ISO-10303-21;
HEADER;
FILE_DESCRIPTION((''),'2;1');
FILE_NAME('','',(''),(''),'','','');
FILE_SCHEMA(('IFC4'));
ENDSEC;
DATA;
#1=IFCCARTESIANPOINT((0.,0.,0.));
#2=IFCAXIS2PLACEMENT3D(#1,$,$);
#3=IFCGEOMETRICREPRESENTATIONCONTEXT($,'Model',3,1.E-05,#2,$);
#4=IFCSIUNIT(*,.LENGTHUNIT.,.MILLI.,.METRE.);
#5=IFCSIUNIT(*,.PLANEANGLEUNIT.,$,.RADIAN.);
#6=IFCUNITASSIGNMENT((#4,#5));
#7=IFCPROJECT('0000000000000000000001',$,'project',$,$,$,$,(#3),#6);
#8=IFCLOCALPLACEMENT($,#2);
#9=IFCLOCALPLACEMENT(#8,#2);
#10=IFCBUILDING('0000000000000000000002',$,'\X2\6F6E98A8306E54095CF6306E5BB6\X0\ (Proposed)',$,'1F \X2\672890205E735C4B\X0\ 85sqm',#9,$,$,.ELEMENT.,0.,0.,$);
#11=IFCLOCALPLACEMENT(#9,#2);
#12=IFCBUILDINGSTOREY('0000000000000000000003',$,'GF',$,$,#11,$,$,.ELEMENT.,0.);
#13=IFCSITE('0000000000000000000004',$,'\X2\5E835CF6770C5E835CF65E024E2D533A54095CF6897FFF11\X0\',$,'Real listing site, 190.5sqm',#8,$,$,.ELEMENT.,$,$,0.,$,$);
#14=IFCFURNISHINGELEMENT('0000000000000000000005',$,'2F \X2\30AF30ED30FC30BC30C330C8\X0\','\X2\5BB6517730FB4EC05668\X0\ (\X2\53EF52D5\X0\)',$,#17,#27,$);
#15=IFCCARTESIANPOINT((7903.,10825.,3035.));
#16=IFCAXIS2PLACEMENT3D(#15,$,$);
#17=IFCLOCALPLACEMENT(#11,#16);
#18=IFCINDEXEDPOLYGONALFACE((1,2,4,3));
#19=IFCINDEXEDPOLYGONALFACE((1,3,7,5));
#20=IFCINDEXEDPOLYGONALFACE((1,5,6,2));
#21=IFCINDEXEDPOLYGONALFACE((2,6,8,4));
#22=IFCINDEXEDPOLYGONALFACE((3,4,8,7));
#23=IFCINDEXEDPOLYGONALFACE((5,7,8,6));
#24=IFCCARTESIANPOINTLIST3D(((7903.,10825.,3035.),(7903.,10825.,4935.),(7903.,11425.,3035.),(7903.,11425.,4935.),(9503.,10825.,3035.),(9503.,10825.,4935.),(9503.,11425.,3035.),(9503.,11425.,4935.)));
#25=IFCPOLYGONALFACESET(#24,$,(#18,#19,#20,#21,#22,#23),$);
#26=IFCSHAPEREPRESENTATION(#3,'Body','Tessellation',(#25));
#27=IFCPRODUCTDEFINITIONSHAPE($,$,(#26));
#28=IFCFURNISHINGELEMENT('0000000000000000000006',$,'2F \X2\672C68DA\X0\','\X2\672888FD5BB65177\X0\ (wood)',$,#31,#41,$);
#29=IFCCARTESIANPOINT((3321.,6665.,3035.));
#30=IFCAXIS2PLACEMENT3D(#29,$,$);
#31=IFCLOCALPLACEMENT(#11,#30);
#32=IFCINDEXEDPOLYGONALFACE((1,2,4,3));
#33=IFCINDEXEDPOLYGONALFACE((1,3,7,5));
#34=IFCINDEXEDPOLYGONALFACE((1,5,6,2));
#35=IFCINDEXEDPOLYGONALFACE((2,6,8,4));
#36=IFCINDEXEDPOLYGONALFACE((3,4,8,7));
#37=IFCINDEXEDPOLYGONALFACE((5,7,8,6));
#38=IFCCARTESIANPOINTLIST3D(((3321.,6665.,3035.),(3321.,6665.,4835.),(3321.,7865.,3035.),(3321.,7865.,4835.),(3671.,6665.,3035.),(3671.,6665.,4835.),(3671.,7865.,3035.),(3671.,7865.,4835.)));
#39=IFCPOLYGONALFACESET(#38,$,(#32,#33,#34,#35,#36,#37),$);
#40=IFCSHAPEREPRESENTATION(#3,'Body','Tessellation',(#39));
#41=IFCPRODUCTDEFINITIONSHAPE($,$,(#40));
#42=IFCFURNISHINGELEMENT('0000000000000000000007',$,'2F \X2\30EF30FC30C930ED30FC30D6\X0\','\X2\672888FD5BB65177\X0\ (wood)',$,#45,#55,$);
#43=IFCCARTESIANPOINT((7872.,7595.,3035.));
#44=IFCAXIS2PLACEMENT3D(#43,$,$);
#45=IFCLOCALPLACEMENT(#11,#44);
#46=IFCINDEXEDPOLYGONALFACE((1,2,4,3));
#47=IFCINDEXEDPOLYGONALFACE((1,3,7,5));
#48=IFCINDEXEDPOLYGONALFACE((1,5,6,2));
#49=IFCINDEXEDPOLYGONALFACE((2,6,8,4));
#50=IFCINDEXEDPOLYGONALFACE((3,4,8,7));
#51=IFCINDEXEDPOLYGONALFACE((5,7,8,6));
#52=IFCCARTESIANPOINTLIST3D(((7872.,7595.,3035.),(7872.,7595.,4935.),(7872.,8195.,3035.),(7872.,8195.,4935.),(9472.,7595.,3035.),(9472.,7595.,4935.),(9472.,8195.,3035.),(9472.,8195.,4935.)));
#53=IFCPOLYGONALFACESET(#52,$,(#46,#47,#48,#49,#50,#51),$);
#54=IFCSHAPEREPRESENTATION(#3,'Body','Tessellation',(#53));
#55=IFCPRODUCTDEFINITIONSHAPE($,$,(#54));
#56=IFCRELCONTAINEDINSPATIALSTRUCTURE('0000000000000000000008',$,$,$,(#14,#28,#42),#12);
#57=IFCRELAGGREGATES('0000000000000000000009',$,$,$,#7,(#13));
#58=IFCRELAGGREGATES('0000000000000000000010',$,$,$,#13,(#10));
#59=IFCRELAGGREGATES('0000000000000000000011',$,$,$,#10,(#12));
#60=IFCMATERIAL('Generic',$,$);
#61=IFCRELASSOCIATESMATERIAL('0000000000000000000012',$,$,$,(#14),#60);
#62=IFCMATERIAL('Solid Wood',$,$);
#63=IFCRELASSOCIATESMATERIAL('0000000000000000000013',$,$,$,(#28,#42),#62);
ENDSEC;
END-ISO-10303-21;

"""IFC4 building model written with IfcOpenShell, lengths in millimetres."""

from ifc_helpers import new_model, si_unit, frame, frame_2d, origin, place, context, project, spatial, rectangle, extrude, material, element, save


model = new_model("IFC4")

# Units and contexts
model_context = context("Model", 3, precision=1e-05, world=origin())
ifc_project = project(units=[si_unit("LENGTHUNIT", "METRE", prefix="MILLI"), si_unit("PLANEANGLEUNIT", "RADIAN")], contexts=[model_context])

# Site, building, storey
site_placement = place(None, origin())
site = spatial("IfcSite", under=ifc_project, at=site_placement, Name="広島県広島市中区吉島西１", ObjectType="Real listing site, 190.5sqm", CompositionType="ELEMENT", RefElevation=0.0)
building_placement = place(site_placement, origin())
building = spatial("IfcBuilding", under=site, at=building_placement, Name="潮風の吉島の家 (Proposed)", ObjectType="1F 木造平屋 85sqm", CompositionType="ELEMENT", ElevationOfRefHeight=0.0, ElevationOfTerrain=0.0)
storey_placement = place(building_placement, origin())
storey = spatial("IfcBuildingStorey", under=building, at=storey_placement, Name="GF", CompositionType="ELEMENT", Elevation=0.0)

# Shared definitions
ifc_material_1 = material(Name="Solid Wood")

# Shared definitions
ifc_material_2 = material(Name="Generic")

# Furnishing elements
furnishing_1_placement = place(storey_placement, frame((7903.0, 10825.0, 3035.0)))
element("IfcFurnishingElement", 1, at=furnishing_1_placement, inside=storey, material=ifc_material_2, Name="2F クローゼット", Description="家具・什器 (可動)", context=model_context, shape_type="SweptSolid", body=[
    extrude(rectangle(XDim=1600.0, YDim=600.0, at=frame_2d((800.0, 300.0))), frame((7903.0, 10825.0, 3035.0)), (0.0, 0.0, 1.0), 1900.0),
])
furnishing_2_placement = place(storey_placement, frame((3321.0, 6665.0, 3035.0)))
element("IfcFurnishingElement", 2, at=furnishing_2_placement, inside=storey, material=ifc_material_1, Name="2F 本棚", Description="木製家具 (wood)", context=model_context, shape_type="SweptSolid", body=[
    extrude(rectangle(XDim=350.0, YDim=1200.0, at=frame_2d((175.0, 600.0))), frame((3321.0, 6665.0, 3035.0)), (0.0, 0.0, 1.0), 1800.0),
])
furnishing_3_placement = place(storey_placement, frame((7872.0, 7595.0, 3035.0)))
element("IfcFurnishingElement", 3, at=furnishing_3_placement, inside=storey, material=ifc_material_1, Name="2F ワードローブ", Description="木製家具 (wood)", context=model_context, shape_type="SweptSolid", body=[
    extrude(rectangle(XDim=1600.0, YDim=600.0, at=frame_2d((800.0, 300.0))), frame((7872.0, 7595.0, 3035.0)), (0.0, 0.0, 1.0), 1900.0),
])

save(model, "model.ifc")
